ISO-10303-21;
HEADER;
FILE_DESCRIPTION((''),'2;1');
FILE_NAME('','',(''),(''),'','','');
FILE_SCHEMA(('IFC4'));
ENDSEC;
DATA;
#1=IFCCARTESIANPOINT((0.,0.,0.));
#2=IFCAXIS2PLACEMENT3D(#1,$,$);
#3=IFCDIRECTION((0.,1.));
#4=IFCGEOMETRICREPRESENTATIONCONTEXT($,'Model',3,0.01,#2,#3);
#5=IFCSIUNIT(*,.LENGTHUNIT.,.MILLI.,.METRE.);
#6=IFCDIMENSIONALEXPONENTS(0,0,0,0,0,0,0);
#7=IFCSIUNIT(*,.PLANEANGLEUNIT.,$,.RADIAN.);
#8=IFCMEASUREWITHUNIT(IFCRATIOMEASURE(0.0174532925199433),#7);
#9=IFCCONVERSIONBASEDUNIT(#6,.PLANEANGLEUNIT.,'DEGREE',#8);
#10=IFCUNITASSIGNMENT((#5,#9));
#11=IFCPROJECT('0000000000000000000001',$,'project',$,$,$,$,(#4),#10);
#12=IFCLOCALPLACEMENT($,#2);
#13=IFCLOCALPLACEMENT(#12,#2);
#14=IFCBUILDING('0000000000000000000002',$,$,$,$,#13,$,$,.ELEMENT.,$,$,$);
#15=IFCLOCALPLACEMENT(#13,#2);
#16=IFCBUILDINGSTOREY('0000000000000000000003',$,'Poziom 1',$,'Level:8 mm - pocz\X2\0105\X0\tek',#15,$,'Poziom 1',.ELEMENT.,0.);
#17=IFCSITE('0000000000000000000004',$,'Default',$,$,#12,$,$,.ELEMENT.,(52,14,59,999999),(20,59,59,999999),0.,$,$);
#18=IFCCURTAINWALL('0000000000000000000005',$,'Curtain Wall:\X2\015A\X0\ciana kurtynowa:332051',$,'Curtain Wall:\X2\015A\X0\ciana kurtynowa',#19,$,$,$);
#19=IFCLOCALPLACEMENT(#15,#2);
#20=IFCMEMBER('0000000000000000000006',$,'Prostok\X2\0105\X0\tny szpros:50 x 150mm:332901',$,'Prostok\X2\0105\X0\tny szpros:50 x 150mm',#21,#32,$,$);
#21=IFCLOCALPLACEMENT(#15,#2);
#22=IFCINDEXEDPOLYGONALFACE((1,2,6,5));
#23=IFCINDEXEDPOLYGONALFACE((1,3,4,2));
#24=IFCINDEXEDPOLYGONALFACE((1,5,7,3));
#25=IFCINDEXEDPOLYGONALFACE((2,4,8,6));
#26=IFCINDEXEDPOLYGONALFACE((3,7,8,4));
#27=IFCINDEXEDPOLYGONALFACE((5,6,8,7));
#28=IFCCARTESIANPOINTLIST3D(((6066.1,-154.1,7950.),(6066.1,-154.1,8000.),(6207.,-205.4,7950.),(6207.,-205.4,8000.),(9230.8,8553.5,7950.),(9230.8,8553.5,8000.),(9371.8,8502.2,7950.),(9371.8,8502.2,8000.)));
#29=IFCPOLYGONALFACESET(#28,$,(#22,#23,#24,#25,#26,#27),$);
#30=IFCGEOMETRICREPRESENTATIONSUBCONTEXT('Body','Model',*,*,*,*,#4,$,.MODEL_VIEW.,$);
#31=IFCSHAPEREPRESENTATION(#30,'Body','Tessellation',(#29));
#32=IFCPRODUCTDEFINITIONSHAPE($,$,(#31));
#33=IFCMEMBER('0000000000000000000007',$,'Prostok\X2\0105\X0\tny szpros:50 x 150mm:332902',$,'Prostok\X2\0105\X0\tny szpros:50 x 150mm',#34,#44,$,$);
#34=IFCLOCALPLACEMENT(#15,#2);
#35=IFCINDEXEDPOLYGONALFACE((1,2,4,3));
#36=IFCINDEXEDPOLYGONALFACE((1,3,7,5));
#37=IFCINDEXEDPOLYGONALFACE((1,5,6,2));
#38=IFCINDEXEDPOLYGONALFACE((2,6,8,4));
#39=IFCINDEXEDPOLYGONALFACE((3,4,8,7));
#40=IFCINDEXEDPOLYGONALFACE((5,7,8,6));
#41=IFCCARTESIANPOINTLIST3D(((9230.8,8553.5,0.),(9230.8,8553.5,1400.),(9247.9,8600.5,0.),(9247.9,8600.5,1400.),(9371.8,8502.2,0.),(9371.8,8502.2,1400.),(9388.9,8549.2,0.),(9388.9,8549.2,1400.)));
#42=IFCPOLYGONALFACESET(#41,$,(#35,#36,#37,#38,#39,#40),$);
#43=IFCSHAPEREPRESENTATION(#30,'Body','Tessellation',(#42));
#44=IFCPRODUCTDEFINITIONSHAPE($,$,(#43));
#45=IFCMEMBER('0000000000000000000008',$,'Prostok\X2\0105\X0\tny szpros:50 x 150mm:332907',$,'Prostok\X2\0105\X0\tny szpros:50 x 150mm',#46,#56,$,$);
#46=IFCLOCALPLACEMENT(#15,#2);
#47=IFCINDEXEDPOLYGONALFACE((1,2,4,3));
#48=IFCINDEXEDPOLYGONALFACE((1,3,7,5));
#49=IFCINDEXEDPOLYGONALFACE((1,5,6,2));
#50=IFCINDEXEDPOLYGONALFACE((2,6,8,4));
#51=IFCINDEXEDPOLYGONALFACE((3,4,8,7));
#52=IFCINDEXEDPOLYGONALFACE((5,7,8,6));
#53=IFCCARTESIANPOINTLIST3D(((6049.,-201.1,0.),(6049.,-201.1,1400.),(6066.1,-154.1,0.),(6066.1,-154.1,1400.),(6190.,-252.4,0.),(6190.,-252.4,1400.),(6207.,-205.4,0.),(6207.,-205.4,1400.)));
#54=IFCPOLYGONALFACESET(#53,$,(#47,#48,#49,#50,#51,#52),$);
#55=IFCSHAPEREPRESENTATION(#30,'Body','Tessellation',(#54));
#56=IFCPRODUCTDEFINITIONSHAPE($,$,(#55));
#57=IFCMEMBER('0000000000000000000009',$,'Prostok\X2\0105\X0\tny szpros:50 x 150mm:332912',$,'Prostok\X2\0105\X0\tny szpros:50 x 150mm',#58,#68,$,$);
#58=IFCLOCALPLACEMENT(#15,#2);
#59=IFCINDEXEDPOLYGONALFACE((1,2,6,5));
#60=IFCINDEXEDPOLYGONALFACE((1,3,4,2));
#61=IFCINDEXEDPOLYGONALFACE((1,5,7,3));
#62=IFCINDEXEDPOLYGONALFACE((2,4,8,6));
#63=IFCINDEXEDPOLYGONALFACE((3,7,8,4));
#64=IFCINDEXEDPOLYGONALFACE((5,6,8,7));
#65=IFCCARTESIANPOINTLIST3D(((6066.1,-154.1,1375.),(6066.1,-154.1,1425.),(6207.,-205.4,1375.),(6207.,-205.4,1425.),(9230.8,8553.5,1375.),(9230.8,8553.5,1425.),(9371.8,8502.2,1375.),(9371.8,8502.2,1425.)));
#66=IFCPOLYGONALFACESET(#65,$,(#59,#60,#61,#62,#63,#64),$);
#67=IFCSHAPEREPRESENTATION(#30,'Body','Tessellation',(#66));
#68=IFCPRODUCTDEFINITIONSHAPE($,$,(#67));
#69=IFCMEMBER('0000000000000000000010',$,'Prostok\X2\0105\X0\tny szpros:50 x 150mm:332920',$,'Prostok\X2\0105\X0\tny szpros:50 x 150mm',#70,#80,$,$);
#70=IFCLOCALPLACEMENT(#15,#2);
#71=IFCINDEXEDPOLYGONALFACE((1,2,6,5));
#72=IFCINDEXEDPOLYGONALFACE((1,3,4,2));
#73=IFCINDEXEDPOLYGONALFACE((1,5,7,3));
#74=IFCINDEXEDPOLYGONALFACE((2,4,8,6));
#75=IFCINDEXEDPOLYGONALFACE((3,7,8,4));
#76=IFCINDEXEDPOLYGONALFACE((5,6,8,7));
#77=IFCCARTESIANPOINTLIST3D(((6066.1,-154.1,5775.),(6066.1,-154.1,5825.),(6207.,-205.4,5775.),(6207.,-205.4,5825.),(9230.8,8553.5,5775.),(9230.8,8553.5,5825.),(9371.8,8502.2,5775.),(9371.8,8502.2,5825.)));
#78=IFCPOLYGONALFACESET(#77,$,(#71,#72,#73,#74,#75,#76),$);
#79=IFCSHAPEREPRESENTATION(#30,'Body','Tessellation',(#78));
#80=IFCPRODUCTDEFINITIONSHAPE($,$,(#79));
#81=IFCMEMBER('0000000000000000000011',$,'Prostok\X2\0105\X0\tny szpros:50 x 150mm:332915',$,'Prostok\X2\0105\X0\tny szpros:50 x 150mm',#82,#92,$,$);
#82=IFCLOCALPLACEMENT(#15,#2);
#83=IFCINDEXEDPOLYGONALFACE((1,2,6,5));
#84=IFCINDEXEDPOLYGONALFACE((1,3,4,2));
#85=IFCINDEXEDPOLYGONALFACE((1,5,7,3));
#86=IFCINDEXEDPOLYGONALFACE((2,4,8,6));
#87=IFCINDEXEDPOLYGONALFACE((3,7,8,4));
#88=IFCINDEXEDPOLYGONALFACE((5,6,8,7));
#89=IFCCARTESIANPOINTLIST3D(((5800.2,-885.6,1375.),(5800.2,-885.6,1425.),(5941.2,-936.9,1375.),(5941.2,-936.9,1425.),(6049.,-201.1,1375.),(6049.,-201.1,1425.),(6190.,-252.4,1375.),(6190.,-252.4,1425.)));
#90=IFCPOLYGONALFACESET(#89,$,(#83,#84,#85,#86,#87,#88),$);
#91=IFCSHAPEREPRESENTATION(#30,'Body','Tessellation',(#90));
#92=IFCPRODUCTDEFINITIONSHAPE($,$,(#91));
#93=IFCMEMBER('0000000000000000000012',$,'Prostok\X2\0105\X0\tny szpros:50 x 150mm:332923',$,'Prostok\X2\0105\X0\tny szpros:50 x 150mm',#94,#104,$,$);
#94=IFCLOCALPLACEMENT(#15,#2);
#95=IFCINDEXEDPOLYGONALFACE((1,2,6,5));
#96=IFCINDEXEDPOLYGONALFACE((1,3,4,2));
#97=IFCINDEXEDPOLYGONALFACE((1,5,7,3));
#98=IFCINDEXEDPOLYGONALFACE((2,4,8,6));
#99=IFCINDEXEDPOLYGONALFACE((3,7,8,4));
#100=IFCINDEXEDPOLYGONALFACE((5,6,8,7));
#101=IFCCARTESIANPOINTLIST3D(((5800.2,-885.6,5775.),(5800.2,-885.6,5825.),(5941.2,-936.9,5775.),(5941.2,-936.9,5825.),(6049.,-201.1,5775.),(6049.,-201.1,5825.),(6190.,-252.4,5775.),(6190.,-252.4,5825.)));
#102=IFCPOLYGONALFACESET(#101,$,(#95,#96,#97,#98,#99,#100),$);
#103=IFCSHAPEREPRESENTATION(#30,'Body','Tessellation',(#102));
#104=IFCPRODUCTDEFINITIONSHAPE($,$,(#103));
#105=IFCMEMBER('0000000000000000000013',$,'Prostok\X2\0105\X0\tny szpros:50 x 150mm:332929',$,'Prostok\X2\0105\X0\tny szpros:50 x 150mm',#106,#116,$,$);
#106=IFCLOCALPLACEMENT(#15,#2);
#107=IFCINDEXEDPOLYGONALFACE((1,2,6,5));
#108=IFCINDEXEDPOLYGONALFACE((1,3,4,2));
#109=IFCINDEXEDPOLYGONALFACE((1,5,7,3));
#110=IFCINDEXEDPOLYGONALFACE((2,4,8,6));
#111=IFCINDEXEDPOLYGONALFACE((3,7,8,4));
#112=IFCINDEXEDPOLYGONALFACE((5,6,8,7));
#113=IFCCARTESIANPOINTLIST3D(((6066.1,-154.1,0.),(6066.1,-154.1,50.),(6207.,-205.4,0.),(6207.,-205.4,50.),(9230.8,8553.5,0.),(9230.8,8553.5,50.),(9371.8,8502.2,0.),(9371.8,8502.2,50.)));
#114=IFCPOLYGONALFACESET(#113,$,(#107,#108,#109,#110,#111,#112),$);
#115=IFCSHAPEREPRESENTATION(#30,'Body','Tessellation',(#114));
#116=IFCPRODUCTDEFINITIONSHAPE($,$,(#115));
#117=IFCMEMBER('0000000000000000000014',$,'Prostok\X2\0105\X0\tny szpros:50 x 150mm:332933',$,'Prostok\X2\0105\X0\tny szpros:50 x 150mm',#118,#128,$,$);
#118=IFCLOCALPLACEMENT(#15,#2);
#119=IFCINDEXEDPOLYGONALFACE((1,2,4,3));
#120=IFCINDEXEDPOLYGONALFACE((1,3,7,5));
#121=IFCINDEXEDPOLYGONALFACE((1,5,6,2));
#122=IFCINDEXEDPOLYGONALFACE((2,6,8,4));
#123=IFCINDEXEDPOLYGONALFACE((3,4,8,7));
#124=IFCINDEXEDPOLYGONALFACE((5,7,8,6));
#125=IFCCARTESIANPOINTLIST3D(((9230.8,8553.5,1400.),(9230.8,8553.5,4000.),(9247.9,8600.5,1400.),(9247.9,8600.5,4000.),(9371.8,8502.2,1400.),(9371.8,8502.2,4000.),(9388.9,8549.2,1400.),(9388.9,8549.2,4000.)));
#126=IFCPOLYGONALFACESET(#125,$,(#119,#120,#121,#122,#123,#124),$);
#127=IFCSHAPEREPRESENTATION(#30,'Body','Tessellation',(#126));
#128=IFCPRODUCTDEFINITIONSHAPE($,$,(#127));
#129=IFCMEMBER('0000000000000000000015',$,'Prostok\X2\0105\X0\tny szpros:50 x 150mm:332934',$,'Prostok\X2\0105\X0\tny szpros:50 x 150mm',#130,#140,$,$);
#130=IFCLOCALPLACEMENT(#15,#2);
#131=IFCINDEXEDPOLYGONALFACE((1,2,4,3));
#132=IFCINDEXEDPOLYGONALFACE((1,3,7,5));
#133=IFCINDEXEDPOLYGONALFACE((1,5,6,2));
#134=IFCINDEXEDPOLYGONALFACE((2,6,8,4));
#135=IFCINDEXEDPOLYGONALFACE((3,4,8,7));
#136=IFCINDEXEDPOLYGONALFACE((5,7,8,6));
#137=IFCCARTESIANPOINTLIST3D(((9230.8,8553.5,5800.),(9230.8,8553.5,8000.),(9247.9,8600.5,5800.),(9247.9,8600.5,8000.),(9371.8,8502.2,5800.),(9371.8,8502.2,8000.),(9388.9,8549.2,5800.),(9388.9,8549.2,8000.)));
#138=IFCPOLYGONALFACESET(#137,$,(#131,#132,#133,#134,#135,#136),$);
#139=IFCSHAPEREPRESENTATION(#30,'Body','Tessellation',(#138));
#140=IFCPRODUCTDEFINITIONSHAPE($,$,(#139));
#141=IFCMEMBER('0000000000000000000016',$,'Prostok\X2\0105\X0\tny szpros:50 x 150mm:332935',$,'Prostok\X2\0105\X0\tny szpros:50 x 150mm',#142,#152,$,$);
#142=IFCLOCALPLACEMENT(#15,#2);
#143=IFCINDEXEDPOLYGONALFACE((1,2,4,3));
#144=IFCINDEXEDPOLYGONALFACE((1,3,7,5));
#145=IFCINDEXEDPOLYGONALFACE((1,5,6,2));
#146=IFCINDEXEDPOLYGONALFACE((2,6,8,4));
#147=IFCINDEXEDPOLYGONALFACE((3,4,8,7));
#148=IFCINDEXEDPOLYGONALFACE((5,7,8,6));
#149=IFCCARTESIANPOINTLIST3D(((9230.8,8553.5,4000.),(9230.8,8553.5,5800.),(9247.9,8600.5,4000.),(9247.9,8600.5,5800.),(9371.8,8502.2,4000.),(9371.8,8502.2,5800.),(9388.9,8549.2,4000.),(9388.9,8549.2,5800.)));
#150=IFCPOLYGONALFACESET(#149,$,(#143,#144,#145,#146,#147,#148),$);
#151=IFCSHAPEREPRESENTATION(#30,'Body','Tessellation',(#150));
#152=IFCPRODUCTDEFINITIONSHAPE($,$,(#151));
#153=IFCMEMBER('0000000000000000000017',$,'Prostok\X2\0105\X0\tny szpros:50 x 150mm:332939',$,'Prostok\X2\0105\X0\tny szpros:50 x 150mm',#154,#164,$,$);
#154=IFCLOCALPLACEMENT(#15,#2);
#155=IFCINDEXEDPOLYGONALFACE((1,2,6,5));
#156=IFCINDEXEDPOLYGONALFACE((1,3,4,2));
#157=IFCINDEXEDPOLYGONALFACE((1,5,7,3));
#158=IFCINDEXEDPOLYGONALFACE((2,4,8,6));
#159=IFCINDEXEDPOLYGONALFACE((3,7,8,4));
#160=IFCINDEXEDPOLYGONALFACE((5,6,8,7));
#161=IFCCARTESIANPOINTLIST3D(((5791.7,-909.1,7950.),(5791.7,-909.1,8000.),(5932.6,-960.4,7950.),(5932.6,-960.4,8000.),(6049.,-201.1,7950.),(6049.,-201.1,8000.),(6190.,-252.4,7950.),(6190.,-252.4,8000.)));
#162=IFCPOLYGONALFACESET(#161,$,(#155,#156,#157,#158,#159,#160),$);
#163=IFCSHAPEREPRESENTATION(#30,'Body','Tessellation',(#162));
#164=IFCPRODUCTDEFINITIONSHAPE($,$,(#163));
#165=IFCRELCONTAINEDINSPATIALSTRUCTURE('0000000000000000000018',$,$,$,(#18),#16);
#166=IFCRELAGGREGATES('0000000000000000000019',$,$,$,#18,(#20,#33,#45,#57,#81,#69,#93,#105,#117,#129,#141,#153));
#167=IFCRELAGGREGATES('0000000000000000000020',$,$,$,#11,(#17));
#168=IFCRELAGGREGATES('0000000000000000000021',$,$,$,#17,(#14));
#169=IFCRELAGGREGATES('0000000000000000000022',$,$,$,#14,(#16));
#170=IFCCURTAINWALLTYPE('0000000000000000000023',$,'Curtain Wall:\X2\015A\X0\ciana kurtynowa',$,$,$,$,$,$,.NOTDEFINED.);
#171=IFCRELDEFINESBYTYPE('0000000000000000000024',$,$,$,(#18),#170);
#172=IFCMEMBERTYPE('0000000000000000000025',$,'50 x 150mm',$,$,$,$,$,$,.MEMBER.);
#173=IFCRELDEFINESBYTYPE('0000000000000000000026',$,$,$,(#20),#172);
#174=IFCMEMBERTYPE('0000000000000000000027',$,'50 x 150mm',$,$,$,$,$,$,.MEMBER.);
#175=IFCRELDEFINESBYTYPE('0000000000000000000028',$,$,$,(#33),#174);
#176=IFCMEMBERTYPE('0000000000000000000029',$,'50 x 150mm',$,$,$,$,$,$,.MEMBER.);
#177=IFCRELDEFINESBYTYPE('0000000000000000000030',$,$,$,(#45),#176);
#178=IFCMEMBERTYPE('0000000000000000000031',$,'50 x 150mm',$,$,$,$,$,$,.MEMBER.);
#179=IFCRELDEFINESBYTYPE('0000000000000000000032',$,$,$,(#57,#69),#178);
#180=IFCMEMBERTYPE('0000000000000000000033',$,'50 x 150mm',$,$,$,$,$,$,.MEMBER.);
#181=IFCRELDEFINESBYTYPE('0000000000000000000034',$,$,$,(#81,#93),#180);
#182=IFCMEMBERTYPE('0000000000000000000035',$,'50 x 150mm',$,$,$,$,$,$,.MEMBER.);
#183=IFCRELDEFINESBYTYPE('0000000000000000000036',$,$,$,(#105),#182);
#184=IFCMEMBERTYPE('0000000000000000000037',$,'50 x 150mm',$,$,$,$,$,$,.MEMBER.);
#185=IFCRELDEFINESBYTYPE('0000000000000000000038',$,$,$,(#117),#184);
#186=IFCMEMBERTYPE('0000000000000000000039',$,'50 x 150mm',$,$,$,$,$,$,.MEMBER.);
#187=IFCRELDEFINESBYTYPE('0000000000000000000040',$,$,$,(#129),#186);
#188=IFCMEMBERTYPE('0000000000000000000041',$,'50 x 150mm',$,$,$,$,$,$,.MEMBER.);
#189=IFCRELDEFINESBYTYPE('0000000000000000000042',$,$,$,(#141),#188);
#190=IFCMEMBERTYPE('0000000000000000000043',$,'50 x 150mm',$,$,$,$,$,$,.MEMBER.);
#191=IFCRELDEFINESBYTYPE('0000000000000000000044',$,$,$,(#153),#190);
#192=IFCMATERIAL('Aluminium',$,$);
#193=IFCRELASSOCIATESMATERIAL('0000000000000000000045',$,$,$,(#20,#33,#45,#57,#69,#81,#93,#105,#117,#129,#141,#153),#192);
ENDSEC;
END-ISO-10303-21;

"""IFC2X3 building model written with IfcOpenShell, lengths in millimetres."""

from ifc_helpers import new_model, entity, si_unit, converted_unit, direction, frame, origin, origin_2d_with_axis, place, context, subcontext, project, spatial, rectangle, extrude, source, transform, mapped, material, type_object, type_shapes, element, aggregate, save


model = new_model("IFC2X3")

# Units and contexts
model_context = context("Model", 3, precision=0.01, world=origin(), true_north=direction((0.0, 1.0)))
body_context = subcontext(model_context, "Body", "Model", "MODEL_VIEW")
ifc_project = project(units=[si_unit("LENGTHUNIT", "METRE", prefix="MILLI"), converted_unit("PLANEANGLEUNIT", "DEGREE", entity("IfcRatioMeasure", 0.0174532925199433), si_unit("PLANEANGLEUNIT", "RADIAN"), dimensions=[0, 0, 0, 0, 0, 0, 0])], contexts=[model_context])

# Site, building, storey
site_placement = place(None, origin())
site = spatial("IfcSite", under=ifc_project, at=site_placement, Name="Default", CompositionType="ELEMENT", RefLatitude=(52, 14, 59, 999999), RefLongitude=(20, 59, 59, 999999), RefElevation=0.0)
building_placement = place(site_placement, origin())
building = spatial("IfcBuilding", under=site, at=building_placement, CompositionType="ELEMENT")
storey_placement = place(building_placement, origin())
storey = spatial("IfcBuildingStorey", under=building, at=storey_placement, Name="Poziom 1", ObjectType="Level:8 mm - początek", LongName="Poziom 1", CompositionType="ELEMENT", Elevation=0.0)

# Curtain wall, members
curtain_wall_type = type_object("IfcCurtainWallType", Name="Curtain Wall:Ściana kurtynowa", PredefinedType="NOTDEFINED")
curtain_wall_placement = place(storey_placement, origin())
curtain_wall = element("IfcCurtainWall", 1, at=curtain_wall_placement, inside=storey, type_object=curtain_wall_type, Name="Curtain Wall:Ściana kurtynowa:332051", ObjectType="Curtain Wall:Ściana kurtynowa")
ifc_material_1 = material(Name="Aluminium")
member_type_1 = type_object("IfcMemberType", Name="50 x 150mm", PredefinedType="MEMBER")
shared_shape_1 = source(origin(), body_context, "Body", "SweptSolid", [
    extrude(rectangle(XDim=150.0, YDim=50.0, at=origin_2d_with_axis()), frame((-25.0, 0.0, -9264.9), z_axis=(0.0, 0.0, 1.0), x_axis=(0.0, -1.0, 0.0)), (0.0, 0.0, 1.0), 9264.9),
])
type_shapes(member_type_1, [shared_shape_1])
member_1_placement = place(storey_placement, frame((9301.3, 8527.9, 8000.0), z_axis=(0.341586, 0.939851, 0.0), x_axis=(0.0, 0.0, 1.0)))
member_1 = element("IfcMember", 2, at=member_1_placement, type_object=member_type_1, material=ifc_material_1, Name="Prostokątny szpros:50 x 150mm:332901", ObjectType="Prostokątny szpros:50 x 150mm", context=body_context, shape_type="MappedRepresentation", body=[
    mapped(shared_shape_1, transform((0.0, 0.0, 0.0), scale=1.0)),
])
member_type_2 = type_object("IfcMemberType", Name="50 x 150mm", PredefinedType="MEMBER")
shared_shape_2 = source(origin(), body_context, "Body", "SweptSolid", [
    extrude(rectangle(XDim=150.0, YDim=50.0, at=origin_2d_with_axis()), frame((-25.0, 0.0, -1400.0), z_axis=(0.0, 0.0, 1.0), x_axis=(0.0, -1.0, 0.0)), (0.0, 0.0, 1.0), 1400.0),
])
type_shapes(member_type_2, [shared_shape_2])
member_2_placement = place(storey_placement, frame((9318.4, 8574.9, 0.0), z_axis=(0.0, 0.0, -1.0), x_axis=(0.341586, 0.939851, 0.0)))
member_2 = element("IfcMember", 3, at=member_2_placement, type_object=member_type_2, material=ifc_material_1, Name="Prostokątny szpros:50 x 150mm:332902", ObjectType="Prostokątny szpros:50 x 150mm", context=body_context, shape_type="MappedRepresentation", body=[
    mapped(shared_shape_2, transform((0.0, 0.0, 0.0), scale=1.0)),
])
member_type_3 = type_object("IfcMemberType", Name="50 x 150mm", PredefinedType="MEMBER")
shared_shape_3 = source(origin(), body_context, "Body", "SweptSolid", [
    extrude(rectangle(XDim=150.0, YDim=50.0, at=origin_2d_with_axis()), frame((0.0, 0.0, -1400.0), z_axis=(0.0, 0.0, 1.0), x_axis=(0.0, -1.0, 0.0)), (0.0, 0.0, 1.0), 1400.0),
])
type_shapes(member_type_3, [shared_shape_3])
member_3_placement = place(storey_placement, frame((6128.0, -203.2, 0.0), z_axis=(0.0, 0.0, -1.0), x_axis=(0.341586, 0.939851, 0.0)))
member_3 = element("IfcMember", 4, at=member_3_placement, type_object=member_type_3, material=ifc_material_1, Name="Prostokątny szpros:50 x 150mm:332907", ObjectType="Prostokątny szpros:50 x 150mm", context=body_context, shape_type="MappedRepresentation", body=[
    mapped(shared_shape_3, transform((0.0, 0.0, 0.0), scale=1.0)),
])
member_type_4 = type_object("IfcMemberType", Name="50 x 150mm", PredefinedType="MEMBER")
shared_shape_4 = source(origin(), body_context, "Body", "SweptSolid", [
    extrude(rectangle(XDim=150.0, YDim=50.0, at=origin_2d_with_axis()), frame((0.0, 0.0, -9264.9), z_axis=(0.0, 0.0, 1.0), x_axis=(0.0, -1.0, 0.0)), (0.0, 0.0, 1.0), 9264.9),
])
type_shapes(member_type_4, [shared_shape_4])
member_4_placement = place(storey_placement, frame((9301.3, 8527.9, 1400.0), z_axis=(0.341586, 0.939851, 0.0), x_axis=(0.0, 0.0, 1.0)))
member_4 = element("IfcMember", 5, at=member_4_placement, type_object=member_type_4, material=ifc_material_1, Name="Prostokątny szpros:50 x 150mm:332912", ObjectType="Prostokątny szpros:50 x 150mm", context=body_context, shape_type="MappedRepresentation", body=[
    mapped(shared_shape_4, transform((0.0, 0.0, 0.0), scale=1.0)),
])
member_5_placement = place(storey_placement, frame((9301.3, 8527.9, 5800.0), z_axis=(0.341586, 0.939851, 0.0), x_axis=(0.0, 0.0, 1.0)))
member_5 = element("IfcMember", 6, at=member_5_placement, type_object=member_type_4, material=ifc_material_1, Name="Prostokątny szpros:50 x 150mm:332920", ObjectType="Prostokątny szpros:50 x 150mm", context=body_context, shape_type="MappedRepresentation", body=[
    mapped(shared_shape_4, transform((0.0, 0.0, 0.0), scale=1.0)),
])
member_type_5 = type_object("IfcMemberType", Name="50 x 150mm", PredefinedType="MEMBER")
shared_shape_5 = source(origin(), body_context, "Body", "SweptSolid", [
    extrude(rectangle(XDim=150.0, YDim=50.0, at=origin_2d_with_axis()), frame((0.0, 0.0, -728.3), z_axis=(0.0, 0.0, 1.0), x_axis=(0.0, -1.0, 0.0)), (0.0, 0.0, 1.0), 728.3),
])
type_shapes(member_type_5, [shared_shape_5])
member_6_placement = place(storey_placement, frame((6119.5, -226.7, 1400.0), z_axis=(0.341586, 0.939851, 0.0), x_axis=(0.0, 0.0, 1.0)))
member_6 = element("IfcMember", 7, at=member_6_placement, type_object=member_type_5, material=ifc_material_1, Name="Prostokątny szpros:50 x 150mm:332915", ObjectType="Prostokątny szpros:50 x 150mm", context=body_context, shape_type="MappedRepresentation", body=[
    mapped(shared_shape_5, transform((0.0, 0.0, 0.0), scale=1.0)),
])
member_7_placement = place(storey_placement, frame((6119.5, -226.7, 5800.0), z_axis=(0.341586, 0.939851, 0.0), x_axis=(0.0, 0.0, 1.0)))
member_7 = element("IfcMember", 8, at=member_7_placement, type_object=member_type_5, material=ifc_material_1, Name="Prostokątny szpros:50 x 150mm:332923", ObjectType="Prostokątny szpros:50 x 150mm", context=body_context, shape_type="MappedRepresentation", body=[
    mapped(shared_shape_5, transform((0.0, 0.0, 0.0), scale=1.0)),
])
member_type_6 = type_object("IfcMemberType", Name="50 x 150mm", PredefinedType="MEMBER")
shared_shape_6 = source(origin(), body_context, "Body", "SweptSolid", [
    extrude(rectangle(XDim=150.0, YDim=50.0, at=origin_2d_with_axis()), frame((-25.0, 0.0, -9264.9), z_axis=(0.0, 0.0, 1.0), x_axis=(0.0, -1.0, 0.0)), (0.0, 0.0, 1.0), 9264.9),
])
type_shapes(member_type_6, [shared_shape_6])
member_8_placement = place(storey_placement, frame((6136.6, -179.7, 0.0), z_axis=(-0.341586, -0.939851, 0.0), x_axis=(0.0, 0.0, -1.0)))
member_8 = element("IfcMember", 9, at=member_8_placement, type_object=member_type_6, material=ifc_material_1, Name="Prostokątny szpros:50 x 150mm:332929", ObjectType="Prostokątny szpros:50 x 150mm", context=body_context, shape_type="MappedRepresentation", body=[
    mapped(shared_shape_6, transform((0.0, 0.0, 0.0), scale=1.0)),
])
member_type_7 = type_object("IfcMemberType", Name="50 x 150mm", PredefinedType="MEMBER")
shared_shape_7 = source(origin(), body_context, "Body", "SweptSolid", [
    extrude(rectangle(XDim=150.0, YDim=50.0, at=origin_2d_with_axis()), frame((-25.0, 0.0, -2600.0), z_axis=(0.0, 0.0, 1.0), x_axis=(0.0, -1.0, 0.0)), (0.0, 0.0, 1.0), 2600.0),
])
type_shapes(member_type_7, [shared_shape_7])
member_9_placement = place(storey_placement, frame((9318.4, 8574.9, 1400.0), z_axis=(0.0, 0.0, -1.0), x_axis=(0.341586, 0.939851, 0.0)))
member_9 = element("IfcMember", 10, at=member_9_placement, type_object=member_type_7, material=ifc_material_1, Name="Prostokątny szpros:50 x 150mm:332933", ObjectType="Prostokątny szpros:50 x 150mm", context=body_context, shape_type="MappedRepresentation", body=[
    mapped(shared_shape_7, transform((0.0, 0.0, 0.0), scale=1.0)),
])
member_type_8 = type_object("IfcMemberType", Name="50 x 150mm", PredefinedType="MEMBER")
shared_shape_8 = source(origin(), body_context, "Body", "SweptSolid", [
    extrude(rectangle(XDim=150.0, YDim=50.0, at=origin_2d_with_axis()), frame((-25.0, 0.0, -2200.0), z_axis=(0.0, 0.0, 1.0), x_axis=(0.0, -1.0, 0.0)), (0.0, 0.0, 1.0), 2200.0),
])
type_shapes(member_type_8, [shared_shape_8])
member_10_placement = place(storey_placement, frame((9318.4, 8574.9, 5800.0), z_axis=(0.0, 0.0, -1.0), x_axis=(0.341586, 0.939851, 0.0)))
member_10 = element("IfcMember", 11, at=member_10_placement, type_object=member_type_8, material=ifc_material_1, Name="Prostokątny szpros:50 x 150mm:332934", ObjectType="Prostokątny szpros:50 x 150mm", context=body_context, shape_type="MappedRepresentation", body=[
    mapped(shared_shape_8, transform((0.0, 0.0, 0.0), scale=1.0)),
])
member_type_9 = type_object("IfcMemberType", Name="50 x 150mm", PredefinedType="MEMBER")
shared_shape_9 = source(origin(), body_context, "Body", "SweptSolid", [
    extrude(rectangle(XDim=150.0, YDim=50.0, at=origin_2d_with_axis()), frame((-25.0, 0.0, -1800.0), z_axis=(0.0, 0.0, 1.0), x_axis=(0.0, -1.0, 0.0)), (0.0, 0.0, 1.0), 1800.0),
])
type_shapes(member_type_9, [shared_shape_9])
member_11_placement = place(storey_placement, frame((9318.4, 8574.9, 4000.0), z_axis=(0.0, 0.0, -1.0), x_axis=(0.341586, 0.939851, 0.0)))
member_11 = element("IfcMember", 12, at=member_11_placement, type_object=member_type_9, material=ifc_material_1, Name="Prostokątny szpros:50 x 150mm:332935", ObjectType="Prostokątny szpros:50 x 150mm", context=body_context, shape_type="MappedRepresentation", body=[
    mapped(shared_shape_9, transform((0.0, 0.0, 0.0), scale=1.0)),
])
member_type_10 = type_object("IfcMemberType", Name="50 x 150mm", PredefinedType="MEMBER")
shared_shape_10 = source(origin(), body_context, "Body", "SweptSolid", [
    extrude(rectangle(XDim=150.0, YDim=50.0, at=origin_2d_with_axis()), frame((-25.0, 0.0, -753.3), z_axis=(0.0, 0.0, 1.0), x_axis=(0.0, -1.0, 0.0)), (0.0, 0.0, 1.0), 753.3),
])
type_shapes(member_type_10, [shared_shape_10])
member_12_placement = place(storey_placement, frame((6119.5, -226.7, 8000.0), z_axis=(0.341586, 0.939851, 0.0), x_axis=(0.0, 0.0, 1.0)))
member_12 = element("IfcMember", 13, at=member_12_placement, type_object=member_type_10, material=ifc_material_1, Name="Prostokątny szpros:50 x 150mm:332939", ObjectType="Prostokątny szpros:50 x 150mm", context=body_context, shape_type="MappedRepresentation", body=[
    mapped(shared_shape_10, transform((0.0, 0.0, 0.0), scale=1.0)),
])
aggregate(curtain_wall, [member_1, member_2, member_3, member_4, member_6, member_5, member_7, member_8, member_9, member_10, member_11, member_12])

save(model, "model.ifc")
